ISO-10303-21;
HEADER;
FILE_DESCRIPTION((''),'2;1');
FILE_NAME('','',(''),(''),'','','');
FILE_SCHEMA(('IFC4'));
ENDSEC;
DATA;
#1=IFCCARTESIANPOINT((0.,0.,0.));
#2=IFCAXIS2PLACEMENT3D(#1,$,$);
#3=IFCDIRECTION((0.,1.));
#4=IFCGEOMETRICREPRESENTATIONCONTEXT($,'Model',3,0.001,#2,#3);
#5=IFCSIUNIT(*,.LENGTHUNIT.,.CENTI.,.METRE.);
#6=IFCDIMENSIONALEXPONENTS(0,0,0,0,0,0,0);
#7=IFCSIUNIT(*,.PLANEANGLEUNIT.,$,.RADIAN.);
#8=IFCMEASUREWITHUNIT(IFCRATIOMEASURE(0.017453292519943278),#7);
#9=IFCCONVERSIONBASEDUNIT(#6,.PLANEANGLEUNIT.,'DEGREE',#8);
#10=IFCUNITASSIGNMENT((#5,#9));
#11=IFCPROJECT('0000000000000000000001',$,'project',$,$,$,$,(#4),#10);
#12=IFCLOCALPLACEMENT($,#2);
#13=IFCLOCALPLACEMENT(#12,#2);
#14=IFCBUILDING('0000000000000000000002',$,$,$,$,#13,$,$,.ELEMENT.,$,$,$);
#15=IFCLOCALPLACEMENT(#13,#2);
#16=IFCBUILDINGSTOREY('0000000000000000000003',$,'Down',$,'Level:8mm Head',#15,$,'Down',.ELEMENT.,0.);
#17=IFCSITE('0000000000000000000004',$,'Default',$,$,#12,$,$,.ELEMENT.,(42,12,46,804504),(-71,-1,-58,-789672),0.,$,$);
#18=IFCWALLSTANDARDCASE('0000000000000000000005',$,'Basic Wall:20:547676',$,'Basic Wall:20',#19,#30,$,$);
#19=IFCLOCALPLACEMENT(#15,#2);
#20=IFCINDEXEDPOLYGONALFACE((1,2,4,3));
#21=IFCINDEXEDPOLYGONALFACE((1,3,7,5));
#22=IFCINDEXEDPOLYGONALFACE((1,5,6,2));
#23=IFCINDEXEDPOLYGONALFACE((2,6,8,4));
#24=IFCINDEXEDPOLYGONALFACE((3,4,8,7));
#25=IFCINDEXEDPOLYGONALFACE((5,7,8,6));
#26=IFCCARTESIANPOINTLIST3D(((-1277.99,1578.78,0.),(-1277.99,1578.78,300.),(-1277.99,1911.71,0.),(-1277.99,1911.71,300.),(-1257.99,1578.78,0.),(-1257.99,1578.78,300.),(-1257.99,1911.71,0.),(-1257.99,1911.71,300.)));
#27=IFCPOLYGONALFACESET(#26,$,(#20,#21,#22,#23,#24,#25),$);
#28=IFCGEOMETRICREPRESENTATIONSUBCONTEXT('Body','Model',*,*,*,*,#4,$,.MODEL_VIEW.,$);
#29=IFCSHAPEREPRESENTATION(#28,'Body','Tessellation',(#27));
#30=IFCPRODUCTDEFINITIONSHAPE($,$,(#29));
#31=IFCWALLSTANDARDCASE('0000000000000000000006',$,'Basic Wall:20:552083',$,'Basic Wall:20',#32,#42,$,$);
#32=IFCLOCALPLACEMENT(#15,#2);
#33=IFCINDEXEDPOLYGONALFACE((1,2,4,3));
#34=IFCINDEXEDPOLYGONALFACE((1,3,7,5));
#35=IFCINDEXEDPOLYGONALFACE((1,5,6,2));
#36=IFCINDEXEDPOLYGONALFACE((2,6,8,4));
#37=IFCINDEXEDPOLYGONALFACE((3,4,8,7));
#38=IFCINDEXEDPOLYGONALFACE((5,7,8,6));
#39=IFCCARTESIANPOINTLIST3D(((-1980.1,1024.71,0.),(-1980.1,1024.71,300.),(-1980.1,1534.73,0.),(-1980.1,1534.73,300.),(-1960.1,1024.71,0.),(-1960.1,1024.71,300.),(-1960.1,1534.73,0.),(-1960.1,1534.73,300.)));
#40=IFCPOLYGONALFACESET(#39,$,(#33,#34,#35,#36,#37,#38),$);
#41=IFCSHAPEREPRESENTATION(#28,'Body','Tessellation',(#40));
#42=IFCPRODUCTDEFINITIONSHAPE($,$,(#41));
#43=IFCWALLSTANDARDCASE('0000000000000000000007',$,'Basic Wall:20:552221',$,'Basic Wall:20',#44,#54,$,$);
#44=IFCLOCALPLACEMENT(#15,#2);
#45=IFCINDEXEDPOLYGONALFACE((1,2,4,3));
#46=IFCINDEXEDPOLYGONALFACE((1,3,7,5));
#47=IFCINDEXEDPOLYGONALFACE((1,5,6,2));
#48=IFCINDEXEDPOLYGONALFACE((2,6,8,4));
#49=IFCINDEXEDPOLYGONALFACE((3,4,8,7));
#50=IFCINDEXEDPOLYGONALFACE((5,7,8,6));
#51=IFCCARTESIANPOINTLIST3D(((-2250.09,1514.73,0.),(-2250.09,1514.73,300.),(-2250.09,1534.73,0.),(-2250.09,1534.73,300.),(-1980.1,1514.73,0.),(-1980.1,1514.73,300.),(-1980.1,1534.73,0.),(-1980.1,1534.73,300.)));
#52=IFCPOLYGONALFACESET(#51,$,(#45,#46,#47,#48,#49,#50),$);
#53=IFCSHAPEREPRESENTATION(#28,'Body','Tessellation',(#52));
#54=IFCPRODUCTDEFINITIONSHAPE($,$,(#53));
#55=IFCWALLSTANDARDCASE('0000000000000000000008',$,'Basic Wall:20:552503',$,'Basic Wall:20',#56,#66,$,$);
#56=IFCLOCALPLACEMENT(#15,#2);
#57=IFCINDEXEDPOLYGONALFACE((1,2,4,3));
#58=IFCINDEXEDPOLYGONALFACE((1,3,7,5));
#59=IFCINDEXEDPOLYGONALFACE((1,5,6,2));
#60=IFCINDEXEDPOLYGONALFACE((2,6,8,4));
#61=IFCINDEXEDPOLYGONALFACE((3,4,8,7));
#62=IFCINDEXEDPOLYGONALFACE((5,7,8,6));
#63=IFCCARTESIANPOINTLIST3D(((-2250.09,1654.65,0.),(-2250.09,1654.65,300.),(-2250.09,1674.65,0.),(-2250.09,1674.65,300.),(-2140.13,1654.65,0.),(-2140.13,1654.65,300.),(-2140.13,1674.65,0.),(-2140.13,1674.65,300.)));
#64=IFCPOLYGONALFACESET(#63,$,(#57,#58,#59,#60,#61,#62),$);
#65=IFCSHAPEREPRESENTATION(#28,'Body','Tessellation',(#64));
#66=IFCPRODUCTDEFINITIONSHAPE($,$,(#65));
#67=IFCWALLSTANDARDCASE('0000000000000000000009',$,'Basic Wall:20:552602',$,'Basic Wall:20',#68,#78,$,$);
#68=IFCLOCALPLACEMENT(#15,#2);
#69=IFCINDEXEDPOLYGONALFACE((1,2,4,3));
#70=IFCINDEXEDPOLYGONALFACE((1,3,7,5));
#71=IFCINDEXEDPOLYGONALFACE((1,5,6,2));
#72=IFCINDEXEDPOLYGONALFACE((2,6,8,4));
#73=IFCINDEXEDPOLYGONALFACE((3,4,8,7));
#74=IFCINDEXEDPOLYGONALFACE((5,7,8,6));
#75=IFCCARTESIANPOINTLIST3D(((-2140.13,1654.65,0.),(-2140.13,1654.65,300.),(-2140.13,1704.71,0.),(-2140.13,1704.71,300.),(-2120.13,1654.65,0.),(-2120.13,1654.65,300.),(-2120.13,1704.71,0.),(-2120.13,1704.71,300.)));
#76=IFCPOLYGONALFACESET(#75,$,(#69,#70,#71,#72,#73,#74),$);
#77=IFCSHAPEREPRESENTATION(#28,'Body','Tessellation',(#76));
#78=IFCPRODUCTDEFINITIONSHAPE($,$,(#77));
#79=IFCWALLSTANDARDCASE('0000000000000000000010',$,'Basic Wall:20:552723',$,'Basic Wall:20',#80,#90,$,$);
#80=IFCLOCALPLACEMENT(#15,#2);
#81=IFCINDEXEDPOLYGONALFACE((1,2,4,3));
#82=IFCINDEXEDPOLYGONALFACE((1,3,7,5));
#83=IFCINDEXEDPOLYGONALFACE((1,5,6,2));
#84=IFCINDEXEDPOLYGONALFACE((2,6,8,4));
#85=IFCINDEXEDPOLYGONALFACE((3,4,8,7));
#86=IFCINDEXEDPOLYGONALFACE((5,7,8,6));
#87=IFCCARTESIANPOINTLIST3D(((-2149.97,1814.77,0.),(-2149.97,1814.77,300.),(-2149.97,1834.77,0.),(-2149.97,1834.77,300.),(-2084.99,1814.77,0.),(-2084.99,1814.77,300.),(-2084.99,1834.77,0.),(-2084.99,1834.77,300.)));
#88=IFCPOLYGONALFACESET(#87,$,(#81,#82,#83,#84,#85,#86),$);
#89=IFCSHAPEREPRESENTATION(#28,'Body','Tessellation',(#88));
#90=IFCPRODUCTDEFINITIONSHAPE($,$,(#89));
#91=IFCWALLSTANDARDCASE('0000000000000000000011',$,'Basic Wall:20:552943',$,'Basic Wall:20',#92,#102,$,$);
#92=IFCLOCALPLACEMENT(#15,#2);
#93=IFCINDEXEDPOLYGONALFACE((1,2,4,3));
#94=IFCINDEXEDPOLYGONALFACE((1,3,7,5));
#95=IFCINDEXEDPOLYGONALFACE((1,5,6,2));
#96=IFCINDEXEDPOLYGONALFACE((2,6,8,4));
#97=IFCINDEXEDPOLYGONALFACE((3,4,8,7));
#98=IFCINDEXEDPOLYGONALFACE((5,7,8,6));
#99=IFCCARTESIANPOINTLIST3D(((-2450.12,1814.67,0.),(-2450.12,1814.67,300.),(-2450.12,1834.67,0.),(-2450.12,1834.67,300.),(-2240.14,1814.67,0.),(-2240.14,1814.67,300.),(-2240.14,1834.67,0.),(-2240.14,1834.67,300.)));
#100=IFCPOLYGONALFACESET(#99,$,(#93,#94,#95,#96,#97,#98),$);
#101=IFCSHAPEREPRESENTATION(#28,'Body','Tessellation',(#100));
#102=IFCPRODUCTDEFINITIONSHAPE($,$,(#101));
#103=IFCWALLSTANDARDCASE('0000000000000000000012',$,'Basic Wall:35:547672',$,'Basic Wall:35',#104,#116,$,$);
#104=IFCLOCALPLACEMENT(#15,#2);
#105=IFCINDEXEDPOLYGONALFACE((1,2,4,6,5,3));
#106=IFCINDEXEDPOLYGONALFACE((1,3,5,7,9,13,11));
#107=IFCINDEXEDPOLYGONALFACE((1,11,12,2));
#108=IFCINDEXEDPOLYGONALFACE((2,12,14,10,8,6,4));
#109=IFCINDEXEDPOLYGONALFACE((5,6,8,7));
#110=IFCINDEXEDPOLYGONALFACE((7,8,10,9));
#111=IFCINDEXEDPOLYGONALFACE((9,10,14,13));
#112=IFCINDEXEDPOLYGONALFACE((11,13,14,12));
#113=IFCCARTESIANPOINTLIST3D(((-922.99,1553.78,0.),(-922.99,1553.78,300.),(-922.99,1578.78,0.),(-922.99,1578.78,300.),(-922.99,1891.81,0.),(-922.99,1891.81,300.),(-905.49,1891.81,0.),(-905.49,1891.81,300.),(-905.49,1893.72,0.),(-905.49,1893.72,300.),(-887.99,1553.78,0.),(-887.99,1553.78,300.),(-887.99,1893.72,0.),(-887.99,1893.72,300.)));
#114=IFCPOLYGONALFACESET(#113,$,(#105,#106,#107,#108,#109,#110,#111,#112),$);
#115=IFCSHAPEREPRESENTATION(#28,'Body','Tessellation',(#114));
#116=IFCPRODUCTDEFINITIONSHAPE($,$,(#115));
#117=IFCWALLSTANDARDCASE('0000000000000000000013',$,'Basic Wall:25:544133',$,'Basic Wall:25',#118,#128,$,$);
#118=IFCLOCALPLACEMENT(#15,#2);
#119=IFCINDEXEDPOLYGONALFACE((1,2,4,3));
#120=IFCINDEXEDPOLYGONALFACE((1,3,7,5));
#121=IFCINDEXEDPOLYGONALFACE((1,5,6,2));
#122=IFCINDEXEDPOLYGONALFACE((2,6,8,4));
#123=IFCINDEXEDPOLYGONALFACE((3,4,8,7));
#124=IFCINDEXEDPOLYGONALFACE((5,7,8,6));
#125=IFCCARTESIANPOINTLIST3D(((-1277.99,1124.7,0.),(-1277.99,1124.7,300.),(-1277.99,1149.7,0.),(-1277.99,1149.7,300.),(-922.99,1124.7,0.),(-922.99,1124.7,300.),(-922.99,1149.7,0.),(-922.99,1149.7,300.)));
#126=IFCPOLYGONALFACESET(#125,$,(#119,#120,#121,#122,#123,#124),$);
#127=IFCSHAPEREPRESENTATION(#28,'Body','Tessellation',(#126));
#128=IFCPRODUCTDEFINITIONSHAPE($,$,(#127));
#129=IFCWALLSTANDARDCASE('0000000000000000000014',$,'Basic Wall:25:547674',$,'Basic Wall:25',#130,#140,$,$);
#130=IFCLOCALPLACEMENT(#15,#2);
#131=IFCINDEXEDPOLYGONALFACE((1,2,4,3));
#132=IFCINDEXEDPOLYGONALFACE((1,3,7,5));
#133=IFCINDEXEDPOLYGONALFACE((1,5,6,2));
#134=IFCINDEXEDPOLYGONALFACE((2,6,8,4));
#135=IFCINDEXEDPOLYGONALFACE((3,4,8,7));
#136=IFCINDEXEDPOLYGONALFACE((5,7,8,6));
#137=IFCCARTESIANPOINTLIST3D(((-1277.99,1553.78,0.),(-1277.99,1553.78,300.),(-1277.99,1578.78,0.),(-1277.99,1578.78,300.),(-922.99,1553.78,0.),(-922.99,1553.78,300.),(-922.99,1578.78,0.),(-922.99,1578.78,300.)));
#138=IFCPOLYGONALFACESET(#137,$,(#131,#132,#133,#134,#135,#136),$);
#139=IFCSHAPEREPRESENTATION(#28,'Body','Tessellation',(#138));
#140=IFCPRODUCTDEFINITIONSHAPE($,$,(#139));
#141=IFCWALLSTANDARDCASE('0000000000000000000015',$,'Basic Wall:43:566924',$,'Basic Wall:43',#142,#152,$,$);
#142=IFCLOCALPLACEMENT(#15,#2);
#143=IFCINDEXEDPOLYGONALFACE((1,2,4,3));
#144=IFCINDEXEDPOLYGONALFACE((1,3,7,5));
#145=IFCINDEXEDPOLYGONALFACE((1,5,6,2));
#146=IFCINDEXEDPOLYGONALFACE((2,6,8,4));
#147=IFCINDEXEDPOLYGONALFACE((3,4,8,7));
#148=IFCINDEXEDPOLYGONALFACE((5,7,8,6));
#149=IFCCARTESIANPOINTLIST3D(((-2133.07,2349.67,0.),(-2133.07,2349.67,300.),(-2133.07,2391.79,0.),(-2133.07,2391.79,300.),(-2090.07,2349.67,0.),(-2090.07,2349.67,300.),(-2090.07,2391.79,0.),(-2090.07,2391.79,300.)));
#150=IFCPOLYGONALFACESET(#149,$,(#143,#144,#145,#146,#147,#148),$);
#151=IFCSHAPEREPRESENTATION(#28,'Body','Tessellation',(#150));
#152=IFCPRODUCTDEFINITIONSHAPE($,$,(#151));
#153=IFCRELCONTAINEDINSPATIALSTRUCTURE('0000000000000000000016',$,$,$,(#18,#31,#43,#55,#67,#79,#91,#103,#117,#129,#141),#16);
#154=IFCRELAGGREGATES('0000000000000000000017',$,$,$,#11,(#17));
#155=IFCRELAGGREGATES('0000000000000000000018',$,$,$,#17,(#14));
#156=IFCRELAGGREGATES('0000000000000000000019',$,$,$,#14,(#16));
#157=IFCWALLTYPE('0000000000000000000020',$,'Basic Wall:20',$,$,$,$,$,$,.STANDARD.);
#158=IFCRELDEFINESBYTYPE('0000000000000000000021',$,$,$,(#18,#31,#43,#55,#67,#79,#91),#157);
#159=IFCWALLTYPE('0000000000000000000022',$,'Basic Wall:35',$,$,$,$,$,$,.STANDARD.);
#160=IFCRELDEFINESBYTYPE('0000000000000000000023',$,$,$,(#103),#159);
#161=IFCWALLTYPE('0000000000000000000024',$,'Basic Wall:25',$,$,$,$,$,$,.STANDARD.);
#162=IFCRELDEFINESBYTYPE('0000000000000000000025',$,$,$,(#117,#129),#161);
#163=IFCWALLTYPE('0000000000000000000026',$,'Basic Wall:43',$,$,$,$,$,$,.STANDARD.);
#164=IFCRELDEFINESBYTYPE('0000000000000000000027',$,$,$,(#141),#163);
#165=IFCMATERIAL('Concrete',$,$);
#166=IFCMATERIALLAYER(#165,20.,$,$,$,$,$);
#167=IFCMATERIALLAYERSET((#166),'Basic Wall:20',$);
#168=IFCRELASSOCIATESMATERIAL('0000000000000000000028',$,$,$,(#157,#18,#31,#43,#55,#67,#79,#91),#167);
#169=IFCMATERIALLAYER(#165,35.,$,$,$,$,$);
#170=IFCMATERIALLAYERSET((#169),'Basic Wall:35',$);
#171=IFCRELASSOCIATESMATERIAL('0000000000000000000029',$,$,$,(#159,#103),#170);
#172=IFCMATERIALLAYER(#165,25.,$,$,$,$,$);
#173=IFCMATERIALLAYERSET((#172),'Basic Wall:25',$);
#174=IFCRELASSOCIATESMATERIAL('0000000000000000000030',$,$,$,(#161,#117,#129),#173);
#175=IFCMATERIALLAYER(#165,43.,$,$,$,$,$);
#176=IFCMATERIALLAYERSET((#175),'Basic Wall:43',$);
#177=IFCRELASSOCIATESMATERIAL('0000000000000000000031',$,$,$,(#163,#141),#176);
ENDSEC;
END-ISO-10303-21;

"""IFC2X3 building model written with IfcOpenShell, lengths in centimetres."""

from ifc_helpers import new_model, entity, si_unit, converted_unit, direction, frame, frame_2d, origin, place, context, subcontext, project, spatial, polyline, rectangle, outline, extrude, material, layer, layer_set, layer_usage, type_object, element, save


model = new_model("IFC2X3")

# Units and contexts
model_context = context("Model", 3, precision=0.001, world=origin(), true_north=direction((0.0, 1.0)))
body_context = subcontext(model_context, "Body", "Model", "MODEL_VIEW")
ifc_project = project(units=[si_unit("LENGTHUNIT", "METRE", prefix="CENTI"), converted_unit("PLANEANGLEUNIT", "DEGREE", entity("IfcRatioMeasure", 0.017453292519943278), si_unit("PLANEANGLEUNIT", "RADIAN"), dimensions=[0, 0, 0, 0, 0, 0, 0])], contexts=[model_context])

# Site, building, storey
site_placement = place(None, origin())
site = spatial("IfcSite", under=ifc_project, at=site_placement, Name="Default", CompositionType="ELEMENT", RefLatitude=(42, 12, 46, 804504), RefLongitude=(-71, -1, -58, -789672), RefElevation=0.0)
building_placement = place(site_placement, origin())
building = spatial("IfcBuilding", under=site, at=building_placement, CompositionType="ELEMENT")
storey_placement = place(building_placement, origin())
storey = spatial("IfcBuildingStorey", under=building, at=storey_placement, Name="Down", ObjectType="Level:8mm Head", LongName="Down", CompositionType="ELEMENT", Elevation=0.0)

# Walls
ifc_material = material(Name="Concrete")
ifc_layer_1 = layer(ifc_material, 20.0)
ifc_layer_set_1 = layer_set([ifc_layer_1], Name="Basic Wall:20")
wall_type_1 = type_object("IfcWallType", Name="Basic Wall:20", PredefinedType="STANDARD", material=ifc_layer_set_1)
ifc_layer_usage_1 = layer_usage(ifc_layer_set_1, "AXIS2", "POSITIVE", -10.0)
wall_1_placement = place(storey_placement, frame((-1267.99, 1578.78, 0.0), z_axis=(0.0, 0.0, 1.0), x_axis=(0.0, 1.0, 0.0)))
element("IfcWallStandardCase", 1, at=wall_1_placement, inside=storey, type_object=wall_type_1, material=ifc_layer_usage_1, Name="Basic Wall:20:547676", ObjectType="Basic Wall:20", context=body_context, shape_type="SweptSolid", body=[
    extrude(rectangle(XDim=332.94, YDim=20.0, at=frame_2d((166.47, 0.0), x_axis=(-1.0, 0.0))), origin(), (0.0, 0.0, 1.0), 300.0),
])
ifc_layer_usage_2 = layer_usage(ifc_layer_set_1, "AXIS2", "POSITIVE", -10.0)
wall_2_placement = place(storey_placement, frame((-1970.1, 1024.71, 0.0), z_axis=(0.0, 0.0, 1.0), x_axis=(0.0, 1.0, 0.0)))
element("IfcWallStandardCase", 2, at=wall_2_placement, inside=storey, type_object=wall_type_1, material=ifc_layer_usage_2, Name="Basic Wall:20:552083", ObjectType="Basic Wall:20", context=body_context, shape_type="SweptSolid", body=[
    extrude(rectangle(XDim=510.02, YDim=20.0, at=frame_2d((255.01, 0.0), x_axis=(-1.0, 0.0))), origin(), (0.0, 0.0, 1.0), 300.0),
])
ifc_layer_usage_3 = layer_usage(ifc_layer_set_1, "AXIS2", "POSITIVE", -10.0)
wall_3_placement = place(storey_placement, frame((-1980.1, 1524.73, 0.0), z_axis=(0.0, 0.0, 1.0), x_axis=(-1.0, 0.0, 0.0)))
element("IfcWallStandardCase", 3, at=wall_3_placement, inside=storey, type_object=wall_type_1, material=ifc_layer_usage_3, Name="Basic Wall:20:552221", ObjectType="Basic Wall:20", context=body_context, shape_type="SweptSolid", body=[
    extrude(rectangle(XDim=269.99, YDim=20.0, at=frame_2d((134.99, 0.0), x_axis=(-1.0, 0.0))), origin(), (0.0, 0.0, 1.0), 300.0),
])
ifc_layer_usage_4 = layer_usage(ifc_layer_set_1, "AXIS2", "NEGATIVE", 10.0)
wall_4_placement = place(storey_placement, frame((-2250.09, 1664.65, 0.0)))
element("IfcWallStandardCase", 4, at=wall_4_placement, inside=storey, type_object=wall_type_1, material=ifc_layer_usage_4, Name="Basic Wall:20:552503", ObjectType="Basic Wall:20", context=body_context, shape_type="SweptSolid", body=[
    extrude(rectangle(XDim=109.97, YDim=20.0, at=frame_2d((54.98, 0.0), x_axis=(-1.0, 0.0))), origin(), (0.0, 0.0, 1.0), 300.0),
])
ifc_layer_usage_5 = layer_usage(ifc_layer_set_1, "AXIS2", "POSITIVE", -10.0)
wall_5_placement = place(storey_placement, frame((-2130.13, 1654.65, 0.0), z_axis=(0.0, 0.0, 1.0), x_axis=(0.0, 1.0, 0.0)))
element("IfcWallStandardCase", 5, at=wall_5_placement, inside=storey, type_object=wall_type_1, material=ifc_layer_usage_5, Name="Basic Wall:20:552602", ObjectType="Basic Wall:20", context=body_context, shape_type="SweptSolid", body=[
    extrude(rectangle(XDim=50.06, YDim=20.0, at=frame_2d((25.03, 0.0), x_axis=(-1.0, 0.0))), origin(), (0.0, 0.0, 1.0), 300.0),
])
ifc_layer_usage_6 = layer_usage(ifc_layer_set_1, "AXIS2", "POSITIVE", -10.0)
wall_6_placement = place(storey_placement, frame((-2149.97, 1824.77, 0.0)))
element("IfcWallStandardCase", 6, at=wall_6_placement, inside=storey, type_object=wall_type_1, material=ifc_layer_usage_6, Name="Basic Wall:20:552723", ObjectType="Basic Wall:20", context=body_context, shape_type="SweptSolid", body=[
    extrude(rectangle(XDim=64.98, YDim=20.0, at=frame_2d((32.49, 0.0), x_axis=(-1.0, 0.0))), origin(), (0.0, 0.0, 1.0), 300.0),
])
ifc_layer_usage_7 = layer_usage(ifc_layer_set_1, "AXIS2", "POSITIVE", -10.0)
wall_7_placement = place(storey_placement, frame((-2240.14, 1824.67, 0.0), z_axis=(0.0, 0.0, 1.0), x_axis=(-1.0, 0.0, 0.0)))
element("IfcWallStandardCase", 7, at=wall_7_placement, inside=storey, type_object=wall_type_1, material=ifc_layer_usage_7, Name="Basic Wall:20:552943", ObjectType="Basic Wall:20", context=body_context, shape_type="SweptSolid", body=[
    extrude(rectangle(XDim=209.98, YDim=20.0, at=frame_2d((104.99, 0.0), x_axis=(-1.0, 0.0))), origin(), (0.0, 0.0, 1.0), 300.0),
])
ifc_layer_2 = layer(ifc_material, 35.0)
ifc_layer_set_2 = layer_set([ifc_layer_2], Name="Basic Wall:35")
ifc_layer_usage_8 = layer_usage(ifc_layer_set_2, "AXIS2", "POSITIVE", -17.5)
wall_type_2 = type_object("IfcWallType", Name="Basic Wall:35", PredefinedType="STANDARD", material=ifc_layer_set_2)
wall_8_placement = place(storey_placement, frame((-905.49, 1893.72, 0.0), z_axis=(0.0, 0.0, 1.0), x_axis=(0.0, -1.0, 0.0)))
element("IfcWallStandardCase", 8, at=wall_8_placement, inside=storey, type_object=wall_type_2, material=ifc_layer_usage_8, Name="Basic Wall:35:547672", ObjectType="Basic Wall:35", context=body_context, shape_type="SweptSolid", body=[
    extrude(outline(polyline([(339.94, -17.5), (339.94, 17.5), (0.0, 17.5), (0.0, 0.0), (1.91, 0.0), (1.91, -17.5), (314.94, -17.5), (339.94, -17.5)])), origin(), (0.0, 0.0, 1.0), 300.0),
])
ifc_layer_3 = layer(ifc_material, 25.0)
ifc_layer_set_3 = layer_set([ifc_layer_3], Name="Basic Wall:25")
ifc_layer_usage_9 = layer_usage(ifc_layer_set_3, "AXIS2", "POSITIVE", -12.5)
wall_type_3 = type_object("IfcWallType", Name="Basic Wall:25", PredefinedType="STANDARD", material=ifc_layer_set_3)
wall_9_placement = place(storey_placement, frame((-922.99, 1137.2, 0.0), z_axis=(0.0, 0.0, 1.0), x_axis=(-1.0, 0.0, 0.0)))
element("IfcWallStandardCase", 9, at=wall_9_placement, inside=storey, type_object=wall_type_3, material=ifc_layer_usage_9, Name="Basic Wall:25:544133", ObjectType="Basic Wall:25", context=body_context, shape_type="SweptSolid", body=[
    extrude(rectangle(XDim=355.0, YDim=25.0, at=frame_2d((177.5, 0.0), x_axis=(-1.0, 0.0))), origin(), (0.0, 0.0, 1.0), 300.0),
])
ifc_layer_usage_10 = layer_usage(ifc_layer_set_3, "AXIS2", "NEGATIVE", 12.5)
wall_10_placement = place(storey_placement, frame((-922.99, 1566.28, 0.0), z_axis=(0.0, 0.0, 1.0), x_axis=(-1.0, 0.0, 0.0)))
element("IfcWallStandardCase", 10, at=wall_10_placement, inside=storey, type_object=wall_type_3, material=ifc_layer_usage_10, Name="Basic Wall:25:547674", ObjectType="Basic Wall:25", context=body_context, shape_type="SweptSolid", body=[
    extrude(rectangle(XDim=355.0, YDim=25.0, at=frame_2d((177.5, 0.0), x_axis=(-1.0, 0.0))), origin(), (0.0, 0.0, 1.0), 300.0),
])
ifc_layer_4 = layer(ifc_material, 43.0)
ifc_layer_set_4 = layer_set([ifc_layer_4], Name="Basic Wall:43")
ifc_layer_usage_11 = layer_usage(ifc_layer_set_4, "AXIS2", "POSITIVE", -21.5)
wall_type_4 = type_object("IfcWallType", Name="Basic Wall:43", PredefinedType="STANDARD", material=ifc_layer_set_4)
wall_11_placement = place(storey_placement, frame((-2111.57, 2391.79, 0.0), z_axis=(0.0, 0.0, 1.0), x_axis=(0.0, -1.0, 0.0)))
element("IfcWallStandardCase", 11, at=wall_11_placement, inside=storey, type_object=wall_type_4, material=ifc_layer_usage_11, Name="Basic Wall:43:566924", ObjectType="Basic Wall:43", context=body_context, shape_type="SweptSolid", body=[
    extrude(rectangle(XDim=42.11, YDim=43.0, at=frame_2d((21.06, 0.0), x_axis=(-1.0, 0.0))), origin(), (0.0, 0.0, 1.0), 300.0),
])

save(model, "model.ifc")
